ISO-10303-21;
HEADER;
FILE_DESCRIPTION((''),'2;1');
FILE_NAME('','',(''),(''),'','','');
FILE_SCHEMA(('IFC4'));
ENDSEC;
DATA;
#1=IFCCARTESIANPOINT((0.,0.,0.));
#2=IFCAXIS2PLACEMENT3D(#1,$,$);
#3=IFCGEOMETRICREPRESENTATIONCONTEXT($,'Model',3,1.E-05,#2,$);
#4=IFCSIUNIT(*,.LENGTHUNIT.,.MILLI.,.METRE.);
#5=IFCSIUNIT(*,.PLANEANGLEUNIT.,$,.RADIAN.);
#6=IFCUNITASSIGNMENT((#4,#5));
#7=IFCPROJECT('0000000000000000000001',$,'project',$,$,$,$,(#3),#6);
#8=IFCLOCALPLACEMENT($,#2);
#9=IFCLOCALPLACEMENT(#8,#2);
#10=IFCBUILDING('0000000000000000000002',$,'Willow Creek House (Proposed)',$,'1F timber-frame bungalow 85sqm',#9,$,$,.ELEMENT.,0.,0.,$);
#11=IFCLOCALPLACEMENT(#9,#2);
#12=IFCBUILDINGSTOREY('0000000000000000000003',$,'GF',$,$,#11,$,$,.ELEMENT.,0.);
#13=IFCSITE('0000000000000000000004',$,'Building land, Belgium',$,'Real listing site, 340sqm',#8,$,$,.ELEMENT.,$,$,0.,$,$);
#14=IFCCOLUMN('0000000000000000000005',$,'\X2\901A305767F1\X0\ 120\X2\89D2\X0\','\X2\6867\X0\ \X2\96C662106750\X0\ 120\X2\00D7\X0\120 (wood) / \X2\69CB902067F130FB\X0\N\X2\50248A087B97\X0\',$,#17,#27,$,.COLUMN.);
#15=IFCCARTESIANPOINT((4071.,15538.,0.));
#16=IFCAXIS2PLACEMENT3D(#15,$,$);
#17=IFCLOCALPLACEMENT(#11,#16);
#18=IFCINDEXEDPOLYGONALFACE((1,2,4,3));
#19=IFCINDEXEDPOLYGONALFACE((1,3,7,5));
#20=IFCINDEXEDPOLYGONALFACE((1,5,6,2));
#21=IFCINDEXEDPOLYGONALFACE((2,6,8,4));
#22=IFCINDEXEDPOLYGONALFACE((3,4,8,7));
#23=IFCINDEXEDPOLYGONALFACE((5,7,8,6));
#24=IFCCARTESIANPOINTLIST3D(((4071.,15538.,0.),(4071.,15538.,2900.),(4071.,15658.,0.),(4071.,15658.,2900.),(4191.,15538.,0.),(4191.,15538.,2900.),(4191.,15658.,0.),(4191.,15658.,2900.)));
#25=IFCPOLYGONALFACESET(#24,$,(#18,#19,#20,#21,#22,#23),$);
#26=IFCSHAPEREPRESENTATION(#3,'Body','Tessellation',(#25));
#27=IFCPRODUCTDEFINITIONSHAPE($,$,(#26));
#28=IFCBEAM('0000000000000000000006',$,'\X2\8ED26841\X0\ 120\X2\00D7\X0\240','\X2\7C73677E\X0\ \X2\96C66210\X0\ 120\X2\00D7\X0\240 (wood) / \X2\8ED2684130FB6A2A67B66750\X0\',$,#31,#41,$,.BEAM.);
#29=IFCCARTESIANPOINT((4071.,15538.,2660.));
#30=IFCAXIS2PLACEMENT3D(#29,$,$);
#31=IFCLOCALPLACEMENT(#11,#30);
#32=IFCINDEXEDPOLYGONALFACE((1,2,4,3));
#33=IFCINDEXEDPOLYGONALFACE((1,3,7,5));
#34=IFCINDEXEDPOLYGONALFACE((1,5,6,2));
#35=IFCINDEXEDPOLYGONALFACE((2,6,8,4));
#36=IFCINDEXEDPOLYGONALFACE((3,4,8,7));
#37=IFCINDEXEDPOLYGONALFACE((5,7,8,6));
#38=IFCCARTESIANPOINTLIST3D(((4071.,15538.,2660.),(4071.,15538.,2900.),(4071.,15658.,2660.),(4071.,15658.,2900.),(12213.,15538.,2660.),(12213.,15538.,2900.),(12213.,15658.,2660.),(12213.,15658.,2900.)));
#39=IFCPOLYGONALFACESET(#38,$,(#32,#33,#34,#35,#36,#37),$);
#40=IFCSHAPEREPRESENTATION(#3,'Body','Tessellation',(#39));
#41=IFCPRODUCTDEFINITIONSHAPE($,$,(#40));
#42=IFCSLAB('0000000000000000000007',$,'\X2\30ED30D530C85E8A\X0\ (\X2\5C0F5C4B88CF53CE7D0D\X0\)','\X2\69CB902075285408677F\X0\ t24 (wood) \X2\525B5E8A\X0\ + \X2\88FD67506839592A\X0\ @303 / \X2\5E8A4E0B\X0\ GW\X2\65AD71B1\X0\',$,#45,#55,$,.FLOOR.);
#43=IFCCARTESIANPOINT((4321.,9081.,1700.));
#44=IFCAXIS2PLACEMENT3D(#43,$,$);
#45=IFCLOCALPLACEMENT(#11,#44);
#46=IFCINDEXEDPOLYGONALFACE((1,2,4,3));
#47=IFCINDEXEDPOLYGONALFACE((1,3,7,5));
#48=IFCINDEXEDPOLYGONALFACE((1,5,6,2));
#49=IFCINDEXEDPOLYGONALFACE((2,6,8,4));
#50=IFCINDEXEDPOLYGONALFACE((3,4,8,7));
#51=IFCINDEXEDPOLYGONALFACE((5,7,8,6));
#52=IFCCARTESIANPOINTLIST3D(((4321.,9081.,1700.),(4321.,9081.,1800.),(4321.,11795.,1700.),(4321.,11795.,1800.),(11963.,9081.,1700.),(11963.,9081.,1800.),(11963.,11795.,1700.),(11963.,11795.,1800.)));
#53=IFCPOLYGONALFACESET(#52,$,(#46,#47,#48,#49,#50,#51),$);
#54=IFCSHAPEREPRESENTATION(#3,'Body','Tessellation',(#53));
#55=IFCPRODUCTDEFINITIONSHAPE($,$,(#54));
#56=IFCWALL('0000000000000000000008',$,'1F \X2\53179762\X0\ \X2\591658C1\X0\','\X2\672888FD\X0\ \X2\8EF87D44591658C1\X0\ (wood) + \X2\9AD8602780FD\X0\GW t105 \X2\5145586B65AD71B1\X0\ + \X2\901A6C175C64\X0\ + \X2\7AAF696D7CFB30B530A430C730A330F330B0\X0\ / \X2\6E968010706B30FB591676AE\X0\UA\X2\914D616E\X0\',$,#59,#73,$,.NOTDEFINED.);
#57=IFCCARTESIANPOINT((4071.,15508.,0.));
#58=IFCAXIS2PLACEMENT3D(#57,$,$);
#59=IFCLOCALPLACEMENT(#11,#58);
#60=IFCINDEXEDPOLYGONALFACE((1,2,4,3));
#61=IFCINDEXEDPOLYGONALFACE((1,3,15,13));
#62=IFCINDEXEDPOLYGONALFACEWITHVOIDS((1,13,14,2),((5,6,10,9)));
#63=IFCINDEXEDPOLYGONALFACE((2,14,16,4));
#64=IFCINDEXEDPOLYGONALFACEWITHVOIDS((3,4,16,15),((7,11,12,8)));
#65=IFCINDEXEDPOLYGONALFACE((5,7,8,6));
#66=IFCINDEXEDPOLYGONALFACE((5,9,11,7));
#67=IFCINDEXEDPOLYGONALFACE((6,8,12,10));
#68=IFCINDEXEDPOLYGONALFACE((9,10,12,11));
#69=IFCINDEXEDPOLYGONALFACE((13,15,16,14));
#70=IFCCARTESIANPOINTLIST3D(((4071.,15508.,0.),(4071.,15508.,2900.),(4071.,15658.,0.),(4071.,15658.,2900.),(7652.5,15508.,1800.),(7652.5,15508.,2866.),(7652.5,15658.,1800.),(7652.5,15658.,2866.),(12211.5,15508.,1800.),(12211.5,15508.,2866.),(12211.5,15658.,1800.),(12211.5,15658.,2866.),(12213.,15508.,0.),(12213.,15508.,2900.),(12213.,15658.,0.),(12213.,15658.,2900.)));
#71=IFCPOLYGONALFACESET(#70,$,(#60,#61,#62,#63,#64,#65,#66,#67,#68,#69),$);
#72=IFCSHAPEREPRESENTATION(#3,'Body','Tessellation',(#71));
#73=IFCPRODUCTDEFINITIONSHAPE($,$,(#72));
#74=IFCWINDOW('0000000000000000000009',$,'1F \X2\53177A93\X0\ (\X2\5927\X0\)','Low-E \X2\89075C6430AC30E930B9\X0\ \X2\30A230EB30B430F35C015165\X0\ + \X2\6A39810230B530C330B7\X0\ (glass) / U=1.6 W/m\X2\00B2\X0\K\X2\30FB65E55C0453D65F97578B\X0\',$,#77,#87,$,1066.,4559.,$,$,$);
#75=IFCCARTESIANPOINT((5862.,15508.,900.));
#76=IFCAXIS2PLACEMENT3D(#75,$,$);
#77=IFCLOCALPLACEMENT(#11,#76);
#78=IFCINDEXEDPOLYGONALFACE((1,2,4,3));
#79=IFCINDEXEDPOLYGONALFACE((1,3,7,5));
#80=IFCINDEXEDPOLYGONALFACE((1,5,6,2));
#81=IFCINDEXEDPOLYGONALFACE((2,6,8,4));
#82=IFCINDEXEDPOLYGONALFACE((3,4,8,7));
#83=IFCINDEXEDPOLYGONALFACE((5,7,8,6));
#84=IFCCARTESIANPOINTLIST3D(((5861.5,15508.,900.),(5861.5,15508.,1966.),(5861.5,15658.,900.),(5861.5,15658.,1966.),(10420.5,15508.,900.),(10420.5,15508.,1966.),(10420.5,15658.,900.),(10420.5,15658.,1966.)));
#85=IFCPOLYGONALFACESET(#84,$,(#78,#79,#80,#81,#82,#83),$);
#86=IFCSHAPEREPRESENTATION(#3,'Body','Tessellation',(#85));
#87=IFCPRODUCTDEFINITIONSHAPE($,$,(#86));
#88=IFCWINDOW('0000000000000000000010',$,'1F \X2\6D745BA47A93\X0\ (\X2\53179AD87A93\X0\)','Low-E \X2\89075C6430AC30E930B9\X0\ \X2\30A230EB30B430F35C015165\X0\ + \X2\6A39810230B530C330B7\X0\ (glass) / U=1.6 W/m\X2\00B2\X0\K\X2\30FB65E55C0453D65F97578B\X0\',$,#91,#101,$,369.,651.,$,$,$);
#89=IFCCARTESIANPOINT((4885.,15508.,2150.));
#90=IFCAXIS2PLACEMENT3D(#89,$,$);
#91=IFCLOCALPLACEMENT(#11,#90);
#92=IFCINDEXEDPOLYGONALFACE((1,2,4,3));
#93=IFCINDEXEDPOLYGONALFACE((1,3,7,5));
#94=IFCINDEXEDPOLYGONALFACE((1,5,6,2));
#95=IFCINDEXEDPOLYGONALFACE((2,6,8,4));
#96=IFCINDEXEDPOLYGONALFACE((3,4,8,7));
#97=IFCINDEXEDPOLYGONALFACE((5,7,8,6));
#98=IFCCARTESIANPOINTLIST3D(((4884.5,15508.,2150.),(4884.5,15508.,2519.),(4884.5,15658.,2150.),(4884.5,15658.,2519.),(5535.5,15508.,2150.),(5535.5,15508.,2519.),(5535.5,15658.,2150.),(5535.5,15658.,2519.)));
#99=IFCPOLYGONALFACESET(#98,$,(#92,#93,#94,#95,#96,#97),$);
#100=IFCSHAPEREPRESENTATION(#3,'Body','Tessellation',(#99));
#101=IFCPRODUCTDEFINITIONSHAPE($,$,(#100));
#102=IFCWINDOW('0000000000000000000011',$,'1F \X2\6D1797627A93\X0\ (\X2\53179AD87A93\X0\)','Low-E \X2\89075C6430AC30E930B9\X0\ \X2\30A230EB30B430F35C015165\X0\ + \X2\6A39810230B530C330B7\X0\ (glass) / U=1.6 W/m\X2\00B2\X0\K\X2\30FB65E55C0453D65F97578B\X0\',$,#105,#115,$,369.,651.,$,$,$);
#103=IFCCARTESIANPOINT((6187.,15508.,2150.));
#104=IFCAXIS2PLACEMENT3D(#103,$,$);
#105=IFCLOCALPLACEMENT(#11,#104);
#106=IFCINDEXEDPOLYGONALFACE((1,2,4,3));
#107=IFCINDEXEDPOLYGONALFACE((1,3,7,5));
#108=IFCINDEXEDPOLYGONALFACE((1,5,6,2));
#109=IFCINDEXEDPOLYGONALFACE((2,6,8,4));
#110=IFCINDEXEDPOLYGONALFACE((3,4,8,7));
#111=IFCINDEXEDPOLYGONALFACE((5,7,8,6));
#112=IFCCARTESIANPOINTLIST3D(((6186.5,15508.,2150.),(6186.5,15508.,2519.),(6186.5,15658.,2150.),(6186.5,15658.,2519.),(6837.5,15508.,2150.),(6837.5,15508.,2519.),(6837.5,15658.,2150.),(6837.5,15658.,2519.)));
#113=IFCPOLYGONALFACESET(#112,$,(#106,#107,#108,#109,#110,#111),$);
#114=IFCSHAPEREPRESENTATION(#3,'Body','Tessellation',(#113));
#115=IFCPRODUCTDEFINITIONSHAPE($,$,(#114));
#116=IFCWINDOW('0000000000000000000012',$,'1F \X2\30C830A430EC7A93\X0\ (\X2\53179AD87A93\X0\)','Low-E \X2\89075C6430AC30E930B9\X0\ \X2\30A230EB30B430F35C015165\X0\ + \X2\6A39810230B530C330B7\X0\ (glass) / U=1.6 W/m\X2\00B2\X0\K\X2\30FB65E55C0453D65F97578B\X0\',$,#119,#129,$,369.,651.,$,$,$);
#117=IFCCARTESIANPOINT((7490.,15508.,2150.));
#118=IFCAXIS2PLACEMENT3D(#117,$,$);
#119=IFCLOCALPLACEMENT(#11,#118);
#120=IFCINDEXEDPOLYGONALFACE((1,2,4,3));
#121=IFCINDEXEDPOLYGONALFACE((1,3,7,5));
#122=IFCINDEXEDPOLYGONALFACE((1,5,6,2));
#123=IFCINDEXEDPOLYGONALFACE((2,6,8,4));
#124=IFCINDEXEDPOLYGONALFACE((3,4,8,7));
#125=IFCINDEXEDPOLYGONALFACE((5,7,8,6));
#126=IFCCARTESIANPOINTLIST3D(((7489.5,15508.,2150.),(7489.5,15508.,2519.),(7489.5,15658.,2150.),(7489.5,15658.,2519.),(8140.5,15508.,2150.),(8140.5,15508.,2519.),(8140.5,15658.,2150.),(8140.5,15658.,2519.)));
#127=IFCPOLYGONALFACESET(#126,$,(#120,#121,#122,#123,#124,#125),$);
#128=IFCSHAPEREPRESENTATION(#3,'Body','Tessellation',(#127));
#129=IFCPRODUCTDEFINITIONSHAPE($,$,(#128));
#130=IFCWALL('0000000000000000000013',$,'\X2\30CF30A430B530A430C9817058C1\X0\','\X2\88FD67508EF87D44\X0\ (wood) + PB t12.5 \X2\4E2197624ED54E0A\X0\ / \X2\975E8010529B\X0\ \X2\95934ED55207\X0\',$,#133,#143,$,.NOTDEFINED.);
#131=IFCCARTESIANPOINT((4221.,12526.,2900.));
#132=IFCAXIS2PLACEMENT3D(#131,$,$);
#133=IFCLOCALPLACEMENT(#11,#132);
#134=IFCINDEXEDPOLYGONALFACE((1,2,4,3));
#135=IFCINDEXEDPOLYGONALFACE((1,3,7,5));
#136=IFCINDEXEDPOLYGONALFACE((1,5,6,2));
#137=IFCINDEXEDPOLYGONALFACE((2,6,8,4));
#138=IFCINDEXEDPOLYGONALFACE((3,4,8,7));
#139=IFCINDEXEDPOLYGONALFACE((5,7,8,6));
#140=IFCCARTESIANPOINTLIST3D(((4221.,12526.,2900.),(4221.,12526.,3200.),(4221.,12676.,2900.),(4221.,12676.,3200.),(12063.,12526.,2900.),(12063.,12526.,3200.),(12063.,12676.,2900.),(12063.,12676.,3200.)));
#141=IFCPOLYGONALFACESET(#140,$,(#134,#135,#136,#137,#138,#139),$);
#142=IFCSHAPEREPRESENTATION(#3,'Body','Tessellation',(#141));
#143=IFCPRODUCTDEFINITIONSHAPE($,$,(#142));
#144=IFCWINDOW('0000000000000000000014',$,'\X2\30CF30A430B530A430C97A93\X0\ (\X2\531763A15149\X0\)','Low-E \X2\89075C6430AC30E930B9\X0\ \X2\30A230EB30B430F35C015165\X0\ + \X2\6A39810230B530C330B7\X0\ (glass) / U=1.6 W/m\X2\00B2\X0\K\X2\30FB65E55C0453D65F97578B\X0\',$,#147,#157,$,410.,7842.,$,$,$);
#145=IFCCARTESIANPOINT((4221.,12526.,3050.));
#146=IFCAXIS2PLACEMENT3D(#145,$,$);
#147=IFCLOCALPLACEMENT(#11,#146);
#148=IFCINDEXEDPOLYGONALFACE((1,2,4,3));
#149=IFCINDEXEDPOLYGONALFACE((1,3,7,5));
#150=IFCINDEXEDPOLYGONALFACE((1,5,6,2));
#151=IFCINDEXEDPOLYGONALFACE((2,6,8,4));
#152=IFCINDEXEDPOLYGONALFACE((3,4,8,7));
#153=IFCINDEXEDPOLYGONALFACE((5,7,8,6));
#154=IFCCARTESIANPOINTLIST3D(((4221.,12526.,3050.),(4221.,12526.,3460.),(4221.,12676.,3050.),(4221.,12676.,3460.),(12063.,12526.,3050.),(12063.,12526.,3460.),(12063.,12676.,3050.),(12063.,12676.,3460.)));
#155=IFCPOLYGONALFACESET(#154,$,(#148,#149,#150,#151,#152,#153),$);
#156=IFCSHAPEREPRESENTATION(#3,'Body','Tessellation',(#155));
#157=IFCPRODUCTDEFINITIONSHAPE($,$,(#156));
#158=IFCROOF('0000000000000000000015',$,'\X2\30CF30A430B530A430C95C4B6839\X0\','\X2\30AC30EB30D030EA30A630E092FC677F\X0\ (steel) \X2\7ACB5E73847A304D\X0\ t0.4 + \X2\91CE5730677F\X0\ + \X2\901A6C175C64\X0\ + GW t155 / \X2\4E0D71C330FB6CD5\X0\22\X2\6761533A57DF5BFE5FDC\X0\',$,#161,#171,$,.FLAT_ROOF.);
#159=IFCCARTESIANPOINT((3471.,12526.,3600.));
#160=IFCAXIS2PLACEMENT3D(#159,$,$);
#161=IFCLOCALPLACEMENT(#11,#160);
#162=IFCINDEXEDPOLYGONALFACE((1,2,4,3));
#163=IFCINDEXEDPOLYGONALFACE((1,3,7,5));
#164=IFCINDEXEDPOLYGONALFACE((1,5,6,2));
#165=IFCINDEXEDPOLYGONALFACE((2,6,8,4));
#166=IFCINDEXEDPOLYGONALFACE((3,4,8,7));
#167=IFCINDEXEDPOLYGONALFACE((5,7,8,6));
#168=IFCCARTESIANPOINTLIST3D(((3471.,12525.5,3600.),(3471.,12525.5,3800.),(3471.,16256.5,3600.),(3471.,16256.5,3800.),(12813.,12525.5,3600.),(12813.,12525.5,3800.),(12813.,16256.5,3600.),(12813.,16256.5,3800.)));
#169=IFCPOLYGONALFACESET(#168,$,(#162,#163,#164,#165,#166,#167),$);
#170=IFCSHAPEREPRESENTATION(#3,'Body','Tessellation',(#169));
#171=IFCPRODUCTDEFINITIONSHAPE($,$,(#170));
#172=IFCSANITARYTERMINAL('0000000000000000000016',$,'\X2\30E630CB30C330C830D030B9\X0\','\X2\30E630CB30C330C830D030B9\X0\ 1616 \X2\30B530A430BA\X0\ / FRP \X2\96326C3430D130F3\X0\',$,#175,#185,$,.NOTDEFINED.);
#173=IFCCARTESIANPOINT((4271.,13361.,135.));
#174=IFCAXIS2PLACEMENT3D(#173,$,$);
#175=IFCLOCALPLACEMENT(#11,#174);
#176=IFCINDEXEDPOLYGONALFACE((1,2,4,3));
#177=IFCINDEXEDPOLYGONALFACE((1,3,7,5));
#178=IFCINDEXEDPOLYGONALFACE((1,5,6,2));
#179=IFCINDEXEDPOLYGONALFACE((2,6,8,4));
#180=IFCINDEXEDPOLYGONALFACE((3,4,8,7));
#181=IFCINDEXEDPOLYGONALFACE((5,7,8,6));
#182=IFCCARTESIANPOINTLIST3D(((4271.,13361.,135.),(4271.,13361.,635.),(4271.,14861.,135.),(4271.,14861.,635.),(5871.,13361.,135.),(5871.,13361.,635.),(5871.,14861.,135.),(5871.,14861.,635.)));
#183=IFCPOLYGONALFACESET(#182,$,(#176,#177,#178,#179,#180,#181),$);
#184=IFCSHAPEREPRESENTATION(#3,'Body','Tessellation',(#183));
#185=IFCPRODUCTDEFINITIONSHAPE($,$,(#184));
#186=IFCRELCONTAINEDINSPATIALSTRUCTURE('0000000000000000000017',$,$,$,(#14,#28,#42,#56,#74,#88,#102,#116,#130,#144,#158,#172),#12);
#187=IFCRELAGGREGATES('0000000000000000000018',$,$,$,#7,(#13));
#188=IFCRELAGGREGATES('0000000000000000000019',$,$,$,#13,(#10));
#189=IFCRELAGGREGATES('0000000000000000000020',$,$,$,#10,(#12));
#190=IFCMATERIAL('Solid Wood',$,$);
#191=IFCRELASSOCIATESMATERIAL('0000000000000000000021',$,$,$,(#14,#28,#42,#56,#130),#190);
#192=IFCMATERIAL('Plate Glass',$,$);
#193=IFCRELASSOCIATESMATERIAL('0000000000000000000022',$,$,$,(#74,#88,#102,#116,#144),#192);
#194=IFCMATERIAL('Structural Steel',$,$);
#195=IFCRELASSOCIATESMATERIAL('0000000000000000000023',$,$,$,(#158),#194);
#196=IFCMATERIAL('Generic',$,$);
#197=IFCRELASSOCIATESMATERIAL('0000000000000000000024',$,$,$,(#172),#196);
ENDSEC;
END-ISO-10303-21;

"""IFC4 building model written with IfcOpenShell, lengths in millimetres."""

from ifc_helpers import new_model, si_unit, frame, frame_2d, origin, place, context, project, spatial, rectangle, extrude, material, element, fill, save


model = new_model("IFC4")

# Units and contexts
model_context = context("Model", 3, precision=1e-05, world=origin())
ifc_project = project(units=[si_unit("LENGTHUNIT", "METRE", prefix="MILLI"), si_unit("PLANEANGLEUNIT", "RADIAN")], contexts=[model_context])

# Site, building, storey
site_placement = place(None, origin())
site = spatial("IfcSite", under=ifc_project, at=site_placement, Name="Building land, Belgium", ObjectType="Real listing site, 340sqm", CompositionType="ELEMENT", RefElevation=0.0)
building_placement = place(site_placement, origin())
building = spatial("IfcBuilding", under=site, at=building_placement, Name="Willow Creek House (Proposed)", ObjectType="1F timber-frame bungalow 85sqm", CompositionType="ELEMENT", ElevationOfRefHeight=0.0, ElevationOfTerrain=0.0)
storey_placement = place(building_placement, origin())
storey = spatial("IfcBuildingStorey", under=building, at=storey_placement, Name="GF", CompositionType="ELEMENT", Elevation=0.0)

# Column
ifc_material_1 = material(Name="Solid Wood")
column_1_placement = place(storey_placement, frame((4071.0, 15538.0, 0.0)))
element("IfcColumn", 1, at=column_1_placement, inside=storey, material=ifc_material_1, Name="通し柱 120角", Description="桧 集成材 120×120 (wood) / 構造柱・N値計算", PredefinedType="COLUMN", context=model_context, shape_type="SweptSolid", body=[
    extrude(rectangle(XDim=120.0, YDim=120.0, at=frame_2d((60.0, 60.0))), frame((4071.0, 15538.0, 0.0)), (0.0, 0.0, 1.0), 2900.0),
])

# Beam
beam_1_placement = place(storey_placement, frame((4071.0, 15538.0, 2660.0)))
element("IfcBeam", 2, at=beam_1_placement, inside=storey, material=ifc_material_1, Name="軒桁 120×240", Description="米松 集成 120×240 (wood) / 軒桁・横架材", PredefinedType="BEAM", context=model_context, shape_type="SweptSolid", body=[
    extrude(rectangle(XDim=8142.0, YDim=120.0, at=frame_2d((4071.0, 60.0))), frame((4071.0, 15538.0, 2660.0)), (0.0, 0.0, 1.0), 240.0),
])

# Slab
slab_placement = place(storey_placement, frame((4321.0, 9081.0, 1700.0)))
element("IfcSlab", 3, at=slab_placement, inside=storey, material=ifc_material_1, Name="ロフト床 (小屋裏収納)", Description="構造用合板 t24 (wood) 剛床 + 製材根太 @303 / 床下 GW断熱", PredefinedType="FLOOR", context=model_context, shape_type="SweptSolid", body=[
    extrude(rectangle(XDim=7642.0, YDim=2714.0, at=frame_2d((3821.0, 1357.0))), frame((4321.0, 9081.0, 1700.0)), (0.0, 0.0, 1.0), 100.0),
])

# Wall, openings, windows
wall_1_placement = place(storey_placement, frame((4071.0, 15508.0, 0.0)))
wall_1 = element("IfcWall", 4, at=wall_1_placement, inside=storey, material=ifc_material_1, Name="1F 北面 外壁", Description="木製 軸組外壁 (wood) + 高性能GW t105 充填断熱 + 通気層 + 窯業系サイディング / 準耐火・外皮UA配慮", PredefinedType="NOTDEFINED", context=model_context, shape_type="SweptSolid", body=[
    extrude(rectangle(XDim=8142.0, YDim=150.0, at=frame_2d((4071.0, 75.0))), frame((4071.0, 15508.0, 0.0)), (0.0, 0.0, 1.0), 2900.0),
])
opening_1_placement = place(storey_placement, frame((5862.0, 15508.0, 900.0)))
opening_1 = element("IfcOpeningElement", 5, at=opening_1_placement, cuts=wall_1, PredefinedType="NOTDEFINED", context=model_context, shape_type="SweptSolid", body=[
    extrude(rectangle(XDim=4559.0, YDim=150.0, at=frame_2d((2279.0, 75.0))), frame((5862.0, 15508.0, 900.0)), (0.0, 0.0, 1.0), 1066.0),
])
opening_2_placement = place(storey_placement, frame((4885.0, 15508.0, 2150.0)))
opening_2 = element("IfcOpeningElement", 6, at=opening_2_placement, cuts=wall_1, PredefinedType="NOTDEFINED", context=model_context, shape_type="SweptSolid", body=[
    extrude(rectangle(XDim=651.0, YDim=150.0, at=frame_2d((325.0, 75.0))), frame((4885.0, 15508.0, 2150.0)), (0.0, 0.0, 1.0), 369.0),
])
opening_3_placement = place(storey_placement, frame((6187.0, 15508.0, 2150.0)))
opening_3 = element("IfcOpeningElement", 7, at=opening_3_placement, cuts=wall_1, PredefinedType="NOTDEFINED", context=model_context, shape_type="SweptSolid", body=[
    extrude(rectangle(XDim=651.0, YDim=150.0, at=frame_2d((325.0, 75.0))), frame((6187.0, 15508.0, 2150.0)), (0.0, 0.0, 1.0), 369.0),
])
opening_4_placement = place(storey_placement, frame((7490.0, 15508.0, 2150.0)))
opening_4 = element("IfcOpeningElement", 8, at=opening_4_placement, cuts=wall_1, PredefinedType="NOTDEFINED", context=model_context, shape_type="SweptSolid", body=[
    extrude(rectangle(XDim=651.0, YDim=150.0, at=frame_2d((325.0, 75.0))), frame((7490.0, 15508.0, 2150.0)), (0.0, 0.0, 1.0), 369.0),
])
ifc_material_2 = material(Name="Plate Glass")
window_1_placement = place(storey_placement, frame((5862.0, 15508.0, 900.0)))
window_1 = element("IfcWindow", 9, at=window_1_placement, inside=storey, material=ifc_material_2, Name="1F 北窓 (大)", Description="Low-E 複層ガラス アルゴン封入 + 樹脂サッシ (glass) / U=1.6 W/m²K・日射取得型", OverallHeight=1066.0, OverallWidth=4559.0, context=model_context, shape_type="SweptSolid", body=[
    extrude(rectangle(XDim=4559.0, YDim=150.0, at=frame_2d((2279.0, 75.0))), frame((5862.0, 15508.0, 900.0)), (0.0, 0.0, 1.0), 1066.0),
])
fill(opening_1, window_1)
window_2_placement = place(storey_placement, frame((4885.0, 15508.0, 2150.0)))
window_2 = element("IfcWindow", 10, at=window_2_placement, inside=storey, material=ifc_material_2, Name="1F 浴室窓 (北高窓)", Description="Low-E 複層ガラス アルゴン封入 + 樹脂サッシ (glass) / U=1.6 W/m²K・日射取得型", OverallHeight=369.0, OverallWidth=651.0, context=model_context, shape_type="SweptSolid", body=[
    extrude(rectangle(XDim=651.0, YDim=150.0, at=frame_2d((325.0, 75.0))), frame((4885.0, 15508.0, 2150.0)), (0.0, 0.0, 1.0), 369.0),
])
fill(opening_2, window_2)
window_3_placement = place(storey_placement, frame((6187.0, 15508.0, 2150.0)))
window_3 = element("IfcWindow", 11, at=window_3_placement, inside=storey, material=ifc_material_2, Name="1F 洗面窓 (北高窓)", Description="Low-E 複層ガラス アルゴン封入 + 樹脂サッシ (glass) / U=1.6 W/m²K・日射取得型", OverallHeight=369.0, OverallWidth=651.0, context=model_context, shape_type="SweptSolid", body=[
    extrude(rectangle(XDim=651.0, YDim=150.0, at=frame_2d((325.0, 75.0))), frame((6187.0, 15508.0, 2150.0)), (0.0, 0.0, 1.0), 369.0),
])
fill(opening_3, window_3)
window_4_placement = place(storey_placement, frame((7490.0, 15508.0, 2150.0)))
window_4 = element("IfcWindow", 12, at=window_4_placement, inside=storey, material=ifc_material_2, Name="1F トイレ窓 (北高窓)", Description="Low-E 複層ガラス アルゴン封入 + 樹脂サッシ (glass) / U=1.6 W/m²K・日射取得型", OverallHeight=369.0, OverallWidth=651.0, context=model_context, shape_type="SweptSolid", body=[
    extrude(rectangle(XDim=651.0, YDim=150.0, at=frame_2d((325.0, 75.0))), frame((7490.0, 15508.0, 2150.0)), (0.0, 0.0, 1.0), 369.0),
])
fill(opening_4, window_4)

# Wall, opening, window
wall_2_placement = place(storey_placement, frame((4221.0, 12526.0, 2900.0)))
wall_2 = element("IfcWall", 13, at=wall_2_placement, inside=storey, material=ifc_material_1, Name="ハイサイド腰壁", Description="製材軸組 (wood) + PB t12.5 両面仕上 / 非耐力 間仕切", PredefinedType="NOTDEFINED", context=model_context, shape_type="SweptSolid", body=[
    extrude(rectangle(XDim=7842.0, YDim=150.0, at=frame_2d((3921.0, 75.0))), frame((4221.0, 12526.0, 2900.0)), (0.0, 0.0, 1.0), 700.0),
])
opening_5_placement = place(storey_placement, frame((4221.0, 12526.0, 3050.0)))
opening_5 = element("IfcOpeningElement", 14, at=opening_5_placement, cuts=wall_2, PredefinedType="NOTDEFINED", context=model_context, shape_type="SweptSolid", body=[
    extrude(rectangle(XDim=7842.0, YDim=150.0, at=frame_2d((3921.0, 75.0))), frame((4221.0, 12526.0, 3050.0)), (0.0, 0.0, 1.0), 410.0),
])
window_5_placement = place(storey_placement, frame((4221.0, 12526.0, 3050.0)))
window_5 = element("IfcWindow", 15, at=window_5_placement, inside=storey, material=ifc_material_2, Name="ハイサイド窓 (北採光)", Description="Low-E 複層ガラス アルゴン封入 + 樹脂サッシ (glass) / U=1.6 W/m²K・日射取得型", OverallHeight=410.0, OverallWidth=7842.0, context=model_context, shape_type="SweptSolid", body=[
    extrude(rectangle(XDim=7842.0, YDim=150.0, at=frame_2d((3921.0, 75.0))), frame((4221.0, 12526.0, 3050.0)), (0.0, 0.0, 1.0), 410.0),
])
fill(opening_5, window_5)

# Roof
ifc_material_3 = material(Name="Structural Steel")
roof_placement = place(storey_placement, frame((3471.0, 12526.0, 3600.0)))
element("IfcRoof", 16, at=roof_placement, inside=storey, material=ifc_material_3, Name="ハイサイド屋根", Description="ガルバリウム鋼板 (steel) 立平葺き t0.4 + 野地板 + 通気層 + GW t155 / 不燃・法22条区域対応", PredefinedType="FLAT_ROOF", context=model_context, shape_type="SweptSolid", body=[
    extrude(rectangle(XDim=9342.0, YDim=3731.0, at=frame_2d((4671.0, 1865.0))), frame((3471.0, 12526.0, 3600.0)), (0.0, 0.0, 1.0), 200.0),
])

# Sanitary terminal
ifc_material_4 = material(Name="Generic")
sanitary_terminal_placement = place(storey_placement, frame((4271.0, 13361.0, 135.0)))
element("IfcSanitaryTerminal", 17, at=sanitary_terminal_placement, inside=storey, material=ifc_material_4, Name="ユニットバス", Description="ユニットバス 1616 サイズ / FRP 防水パン", PredefinedType="NOTDEFINED", context=model_context, shape_type="SweptSolid", body=[
    extrude(rectangle(XDim=1600.0, YDim=1500.0, at=frame_2d((800.0, 750.0))), frame((4271.0, 13361.0, 135.0)), (0.0, 0.0, 1.0), 500.0),
])

save(model, "model.ifc")
